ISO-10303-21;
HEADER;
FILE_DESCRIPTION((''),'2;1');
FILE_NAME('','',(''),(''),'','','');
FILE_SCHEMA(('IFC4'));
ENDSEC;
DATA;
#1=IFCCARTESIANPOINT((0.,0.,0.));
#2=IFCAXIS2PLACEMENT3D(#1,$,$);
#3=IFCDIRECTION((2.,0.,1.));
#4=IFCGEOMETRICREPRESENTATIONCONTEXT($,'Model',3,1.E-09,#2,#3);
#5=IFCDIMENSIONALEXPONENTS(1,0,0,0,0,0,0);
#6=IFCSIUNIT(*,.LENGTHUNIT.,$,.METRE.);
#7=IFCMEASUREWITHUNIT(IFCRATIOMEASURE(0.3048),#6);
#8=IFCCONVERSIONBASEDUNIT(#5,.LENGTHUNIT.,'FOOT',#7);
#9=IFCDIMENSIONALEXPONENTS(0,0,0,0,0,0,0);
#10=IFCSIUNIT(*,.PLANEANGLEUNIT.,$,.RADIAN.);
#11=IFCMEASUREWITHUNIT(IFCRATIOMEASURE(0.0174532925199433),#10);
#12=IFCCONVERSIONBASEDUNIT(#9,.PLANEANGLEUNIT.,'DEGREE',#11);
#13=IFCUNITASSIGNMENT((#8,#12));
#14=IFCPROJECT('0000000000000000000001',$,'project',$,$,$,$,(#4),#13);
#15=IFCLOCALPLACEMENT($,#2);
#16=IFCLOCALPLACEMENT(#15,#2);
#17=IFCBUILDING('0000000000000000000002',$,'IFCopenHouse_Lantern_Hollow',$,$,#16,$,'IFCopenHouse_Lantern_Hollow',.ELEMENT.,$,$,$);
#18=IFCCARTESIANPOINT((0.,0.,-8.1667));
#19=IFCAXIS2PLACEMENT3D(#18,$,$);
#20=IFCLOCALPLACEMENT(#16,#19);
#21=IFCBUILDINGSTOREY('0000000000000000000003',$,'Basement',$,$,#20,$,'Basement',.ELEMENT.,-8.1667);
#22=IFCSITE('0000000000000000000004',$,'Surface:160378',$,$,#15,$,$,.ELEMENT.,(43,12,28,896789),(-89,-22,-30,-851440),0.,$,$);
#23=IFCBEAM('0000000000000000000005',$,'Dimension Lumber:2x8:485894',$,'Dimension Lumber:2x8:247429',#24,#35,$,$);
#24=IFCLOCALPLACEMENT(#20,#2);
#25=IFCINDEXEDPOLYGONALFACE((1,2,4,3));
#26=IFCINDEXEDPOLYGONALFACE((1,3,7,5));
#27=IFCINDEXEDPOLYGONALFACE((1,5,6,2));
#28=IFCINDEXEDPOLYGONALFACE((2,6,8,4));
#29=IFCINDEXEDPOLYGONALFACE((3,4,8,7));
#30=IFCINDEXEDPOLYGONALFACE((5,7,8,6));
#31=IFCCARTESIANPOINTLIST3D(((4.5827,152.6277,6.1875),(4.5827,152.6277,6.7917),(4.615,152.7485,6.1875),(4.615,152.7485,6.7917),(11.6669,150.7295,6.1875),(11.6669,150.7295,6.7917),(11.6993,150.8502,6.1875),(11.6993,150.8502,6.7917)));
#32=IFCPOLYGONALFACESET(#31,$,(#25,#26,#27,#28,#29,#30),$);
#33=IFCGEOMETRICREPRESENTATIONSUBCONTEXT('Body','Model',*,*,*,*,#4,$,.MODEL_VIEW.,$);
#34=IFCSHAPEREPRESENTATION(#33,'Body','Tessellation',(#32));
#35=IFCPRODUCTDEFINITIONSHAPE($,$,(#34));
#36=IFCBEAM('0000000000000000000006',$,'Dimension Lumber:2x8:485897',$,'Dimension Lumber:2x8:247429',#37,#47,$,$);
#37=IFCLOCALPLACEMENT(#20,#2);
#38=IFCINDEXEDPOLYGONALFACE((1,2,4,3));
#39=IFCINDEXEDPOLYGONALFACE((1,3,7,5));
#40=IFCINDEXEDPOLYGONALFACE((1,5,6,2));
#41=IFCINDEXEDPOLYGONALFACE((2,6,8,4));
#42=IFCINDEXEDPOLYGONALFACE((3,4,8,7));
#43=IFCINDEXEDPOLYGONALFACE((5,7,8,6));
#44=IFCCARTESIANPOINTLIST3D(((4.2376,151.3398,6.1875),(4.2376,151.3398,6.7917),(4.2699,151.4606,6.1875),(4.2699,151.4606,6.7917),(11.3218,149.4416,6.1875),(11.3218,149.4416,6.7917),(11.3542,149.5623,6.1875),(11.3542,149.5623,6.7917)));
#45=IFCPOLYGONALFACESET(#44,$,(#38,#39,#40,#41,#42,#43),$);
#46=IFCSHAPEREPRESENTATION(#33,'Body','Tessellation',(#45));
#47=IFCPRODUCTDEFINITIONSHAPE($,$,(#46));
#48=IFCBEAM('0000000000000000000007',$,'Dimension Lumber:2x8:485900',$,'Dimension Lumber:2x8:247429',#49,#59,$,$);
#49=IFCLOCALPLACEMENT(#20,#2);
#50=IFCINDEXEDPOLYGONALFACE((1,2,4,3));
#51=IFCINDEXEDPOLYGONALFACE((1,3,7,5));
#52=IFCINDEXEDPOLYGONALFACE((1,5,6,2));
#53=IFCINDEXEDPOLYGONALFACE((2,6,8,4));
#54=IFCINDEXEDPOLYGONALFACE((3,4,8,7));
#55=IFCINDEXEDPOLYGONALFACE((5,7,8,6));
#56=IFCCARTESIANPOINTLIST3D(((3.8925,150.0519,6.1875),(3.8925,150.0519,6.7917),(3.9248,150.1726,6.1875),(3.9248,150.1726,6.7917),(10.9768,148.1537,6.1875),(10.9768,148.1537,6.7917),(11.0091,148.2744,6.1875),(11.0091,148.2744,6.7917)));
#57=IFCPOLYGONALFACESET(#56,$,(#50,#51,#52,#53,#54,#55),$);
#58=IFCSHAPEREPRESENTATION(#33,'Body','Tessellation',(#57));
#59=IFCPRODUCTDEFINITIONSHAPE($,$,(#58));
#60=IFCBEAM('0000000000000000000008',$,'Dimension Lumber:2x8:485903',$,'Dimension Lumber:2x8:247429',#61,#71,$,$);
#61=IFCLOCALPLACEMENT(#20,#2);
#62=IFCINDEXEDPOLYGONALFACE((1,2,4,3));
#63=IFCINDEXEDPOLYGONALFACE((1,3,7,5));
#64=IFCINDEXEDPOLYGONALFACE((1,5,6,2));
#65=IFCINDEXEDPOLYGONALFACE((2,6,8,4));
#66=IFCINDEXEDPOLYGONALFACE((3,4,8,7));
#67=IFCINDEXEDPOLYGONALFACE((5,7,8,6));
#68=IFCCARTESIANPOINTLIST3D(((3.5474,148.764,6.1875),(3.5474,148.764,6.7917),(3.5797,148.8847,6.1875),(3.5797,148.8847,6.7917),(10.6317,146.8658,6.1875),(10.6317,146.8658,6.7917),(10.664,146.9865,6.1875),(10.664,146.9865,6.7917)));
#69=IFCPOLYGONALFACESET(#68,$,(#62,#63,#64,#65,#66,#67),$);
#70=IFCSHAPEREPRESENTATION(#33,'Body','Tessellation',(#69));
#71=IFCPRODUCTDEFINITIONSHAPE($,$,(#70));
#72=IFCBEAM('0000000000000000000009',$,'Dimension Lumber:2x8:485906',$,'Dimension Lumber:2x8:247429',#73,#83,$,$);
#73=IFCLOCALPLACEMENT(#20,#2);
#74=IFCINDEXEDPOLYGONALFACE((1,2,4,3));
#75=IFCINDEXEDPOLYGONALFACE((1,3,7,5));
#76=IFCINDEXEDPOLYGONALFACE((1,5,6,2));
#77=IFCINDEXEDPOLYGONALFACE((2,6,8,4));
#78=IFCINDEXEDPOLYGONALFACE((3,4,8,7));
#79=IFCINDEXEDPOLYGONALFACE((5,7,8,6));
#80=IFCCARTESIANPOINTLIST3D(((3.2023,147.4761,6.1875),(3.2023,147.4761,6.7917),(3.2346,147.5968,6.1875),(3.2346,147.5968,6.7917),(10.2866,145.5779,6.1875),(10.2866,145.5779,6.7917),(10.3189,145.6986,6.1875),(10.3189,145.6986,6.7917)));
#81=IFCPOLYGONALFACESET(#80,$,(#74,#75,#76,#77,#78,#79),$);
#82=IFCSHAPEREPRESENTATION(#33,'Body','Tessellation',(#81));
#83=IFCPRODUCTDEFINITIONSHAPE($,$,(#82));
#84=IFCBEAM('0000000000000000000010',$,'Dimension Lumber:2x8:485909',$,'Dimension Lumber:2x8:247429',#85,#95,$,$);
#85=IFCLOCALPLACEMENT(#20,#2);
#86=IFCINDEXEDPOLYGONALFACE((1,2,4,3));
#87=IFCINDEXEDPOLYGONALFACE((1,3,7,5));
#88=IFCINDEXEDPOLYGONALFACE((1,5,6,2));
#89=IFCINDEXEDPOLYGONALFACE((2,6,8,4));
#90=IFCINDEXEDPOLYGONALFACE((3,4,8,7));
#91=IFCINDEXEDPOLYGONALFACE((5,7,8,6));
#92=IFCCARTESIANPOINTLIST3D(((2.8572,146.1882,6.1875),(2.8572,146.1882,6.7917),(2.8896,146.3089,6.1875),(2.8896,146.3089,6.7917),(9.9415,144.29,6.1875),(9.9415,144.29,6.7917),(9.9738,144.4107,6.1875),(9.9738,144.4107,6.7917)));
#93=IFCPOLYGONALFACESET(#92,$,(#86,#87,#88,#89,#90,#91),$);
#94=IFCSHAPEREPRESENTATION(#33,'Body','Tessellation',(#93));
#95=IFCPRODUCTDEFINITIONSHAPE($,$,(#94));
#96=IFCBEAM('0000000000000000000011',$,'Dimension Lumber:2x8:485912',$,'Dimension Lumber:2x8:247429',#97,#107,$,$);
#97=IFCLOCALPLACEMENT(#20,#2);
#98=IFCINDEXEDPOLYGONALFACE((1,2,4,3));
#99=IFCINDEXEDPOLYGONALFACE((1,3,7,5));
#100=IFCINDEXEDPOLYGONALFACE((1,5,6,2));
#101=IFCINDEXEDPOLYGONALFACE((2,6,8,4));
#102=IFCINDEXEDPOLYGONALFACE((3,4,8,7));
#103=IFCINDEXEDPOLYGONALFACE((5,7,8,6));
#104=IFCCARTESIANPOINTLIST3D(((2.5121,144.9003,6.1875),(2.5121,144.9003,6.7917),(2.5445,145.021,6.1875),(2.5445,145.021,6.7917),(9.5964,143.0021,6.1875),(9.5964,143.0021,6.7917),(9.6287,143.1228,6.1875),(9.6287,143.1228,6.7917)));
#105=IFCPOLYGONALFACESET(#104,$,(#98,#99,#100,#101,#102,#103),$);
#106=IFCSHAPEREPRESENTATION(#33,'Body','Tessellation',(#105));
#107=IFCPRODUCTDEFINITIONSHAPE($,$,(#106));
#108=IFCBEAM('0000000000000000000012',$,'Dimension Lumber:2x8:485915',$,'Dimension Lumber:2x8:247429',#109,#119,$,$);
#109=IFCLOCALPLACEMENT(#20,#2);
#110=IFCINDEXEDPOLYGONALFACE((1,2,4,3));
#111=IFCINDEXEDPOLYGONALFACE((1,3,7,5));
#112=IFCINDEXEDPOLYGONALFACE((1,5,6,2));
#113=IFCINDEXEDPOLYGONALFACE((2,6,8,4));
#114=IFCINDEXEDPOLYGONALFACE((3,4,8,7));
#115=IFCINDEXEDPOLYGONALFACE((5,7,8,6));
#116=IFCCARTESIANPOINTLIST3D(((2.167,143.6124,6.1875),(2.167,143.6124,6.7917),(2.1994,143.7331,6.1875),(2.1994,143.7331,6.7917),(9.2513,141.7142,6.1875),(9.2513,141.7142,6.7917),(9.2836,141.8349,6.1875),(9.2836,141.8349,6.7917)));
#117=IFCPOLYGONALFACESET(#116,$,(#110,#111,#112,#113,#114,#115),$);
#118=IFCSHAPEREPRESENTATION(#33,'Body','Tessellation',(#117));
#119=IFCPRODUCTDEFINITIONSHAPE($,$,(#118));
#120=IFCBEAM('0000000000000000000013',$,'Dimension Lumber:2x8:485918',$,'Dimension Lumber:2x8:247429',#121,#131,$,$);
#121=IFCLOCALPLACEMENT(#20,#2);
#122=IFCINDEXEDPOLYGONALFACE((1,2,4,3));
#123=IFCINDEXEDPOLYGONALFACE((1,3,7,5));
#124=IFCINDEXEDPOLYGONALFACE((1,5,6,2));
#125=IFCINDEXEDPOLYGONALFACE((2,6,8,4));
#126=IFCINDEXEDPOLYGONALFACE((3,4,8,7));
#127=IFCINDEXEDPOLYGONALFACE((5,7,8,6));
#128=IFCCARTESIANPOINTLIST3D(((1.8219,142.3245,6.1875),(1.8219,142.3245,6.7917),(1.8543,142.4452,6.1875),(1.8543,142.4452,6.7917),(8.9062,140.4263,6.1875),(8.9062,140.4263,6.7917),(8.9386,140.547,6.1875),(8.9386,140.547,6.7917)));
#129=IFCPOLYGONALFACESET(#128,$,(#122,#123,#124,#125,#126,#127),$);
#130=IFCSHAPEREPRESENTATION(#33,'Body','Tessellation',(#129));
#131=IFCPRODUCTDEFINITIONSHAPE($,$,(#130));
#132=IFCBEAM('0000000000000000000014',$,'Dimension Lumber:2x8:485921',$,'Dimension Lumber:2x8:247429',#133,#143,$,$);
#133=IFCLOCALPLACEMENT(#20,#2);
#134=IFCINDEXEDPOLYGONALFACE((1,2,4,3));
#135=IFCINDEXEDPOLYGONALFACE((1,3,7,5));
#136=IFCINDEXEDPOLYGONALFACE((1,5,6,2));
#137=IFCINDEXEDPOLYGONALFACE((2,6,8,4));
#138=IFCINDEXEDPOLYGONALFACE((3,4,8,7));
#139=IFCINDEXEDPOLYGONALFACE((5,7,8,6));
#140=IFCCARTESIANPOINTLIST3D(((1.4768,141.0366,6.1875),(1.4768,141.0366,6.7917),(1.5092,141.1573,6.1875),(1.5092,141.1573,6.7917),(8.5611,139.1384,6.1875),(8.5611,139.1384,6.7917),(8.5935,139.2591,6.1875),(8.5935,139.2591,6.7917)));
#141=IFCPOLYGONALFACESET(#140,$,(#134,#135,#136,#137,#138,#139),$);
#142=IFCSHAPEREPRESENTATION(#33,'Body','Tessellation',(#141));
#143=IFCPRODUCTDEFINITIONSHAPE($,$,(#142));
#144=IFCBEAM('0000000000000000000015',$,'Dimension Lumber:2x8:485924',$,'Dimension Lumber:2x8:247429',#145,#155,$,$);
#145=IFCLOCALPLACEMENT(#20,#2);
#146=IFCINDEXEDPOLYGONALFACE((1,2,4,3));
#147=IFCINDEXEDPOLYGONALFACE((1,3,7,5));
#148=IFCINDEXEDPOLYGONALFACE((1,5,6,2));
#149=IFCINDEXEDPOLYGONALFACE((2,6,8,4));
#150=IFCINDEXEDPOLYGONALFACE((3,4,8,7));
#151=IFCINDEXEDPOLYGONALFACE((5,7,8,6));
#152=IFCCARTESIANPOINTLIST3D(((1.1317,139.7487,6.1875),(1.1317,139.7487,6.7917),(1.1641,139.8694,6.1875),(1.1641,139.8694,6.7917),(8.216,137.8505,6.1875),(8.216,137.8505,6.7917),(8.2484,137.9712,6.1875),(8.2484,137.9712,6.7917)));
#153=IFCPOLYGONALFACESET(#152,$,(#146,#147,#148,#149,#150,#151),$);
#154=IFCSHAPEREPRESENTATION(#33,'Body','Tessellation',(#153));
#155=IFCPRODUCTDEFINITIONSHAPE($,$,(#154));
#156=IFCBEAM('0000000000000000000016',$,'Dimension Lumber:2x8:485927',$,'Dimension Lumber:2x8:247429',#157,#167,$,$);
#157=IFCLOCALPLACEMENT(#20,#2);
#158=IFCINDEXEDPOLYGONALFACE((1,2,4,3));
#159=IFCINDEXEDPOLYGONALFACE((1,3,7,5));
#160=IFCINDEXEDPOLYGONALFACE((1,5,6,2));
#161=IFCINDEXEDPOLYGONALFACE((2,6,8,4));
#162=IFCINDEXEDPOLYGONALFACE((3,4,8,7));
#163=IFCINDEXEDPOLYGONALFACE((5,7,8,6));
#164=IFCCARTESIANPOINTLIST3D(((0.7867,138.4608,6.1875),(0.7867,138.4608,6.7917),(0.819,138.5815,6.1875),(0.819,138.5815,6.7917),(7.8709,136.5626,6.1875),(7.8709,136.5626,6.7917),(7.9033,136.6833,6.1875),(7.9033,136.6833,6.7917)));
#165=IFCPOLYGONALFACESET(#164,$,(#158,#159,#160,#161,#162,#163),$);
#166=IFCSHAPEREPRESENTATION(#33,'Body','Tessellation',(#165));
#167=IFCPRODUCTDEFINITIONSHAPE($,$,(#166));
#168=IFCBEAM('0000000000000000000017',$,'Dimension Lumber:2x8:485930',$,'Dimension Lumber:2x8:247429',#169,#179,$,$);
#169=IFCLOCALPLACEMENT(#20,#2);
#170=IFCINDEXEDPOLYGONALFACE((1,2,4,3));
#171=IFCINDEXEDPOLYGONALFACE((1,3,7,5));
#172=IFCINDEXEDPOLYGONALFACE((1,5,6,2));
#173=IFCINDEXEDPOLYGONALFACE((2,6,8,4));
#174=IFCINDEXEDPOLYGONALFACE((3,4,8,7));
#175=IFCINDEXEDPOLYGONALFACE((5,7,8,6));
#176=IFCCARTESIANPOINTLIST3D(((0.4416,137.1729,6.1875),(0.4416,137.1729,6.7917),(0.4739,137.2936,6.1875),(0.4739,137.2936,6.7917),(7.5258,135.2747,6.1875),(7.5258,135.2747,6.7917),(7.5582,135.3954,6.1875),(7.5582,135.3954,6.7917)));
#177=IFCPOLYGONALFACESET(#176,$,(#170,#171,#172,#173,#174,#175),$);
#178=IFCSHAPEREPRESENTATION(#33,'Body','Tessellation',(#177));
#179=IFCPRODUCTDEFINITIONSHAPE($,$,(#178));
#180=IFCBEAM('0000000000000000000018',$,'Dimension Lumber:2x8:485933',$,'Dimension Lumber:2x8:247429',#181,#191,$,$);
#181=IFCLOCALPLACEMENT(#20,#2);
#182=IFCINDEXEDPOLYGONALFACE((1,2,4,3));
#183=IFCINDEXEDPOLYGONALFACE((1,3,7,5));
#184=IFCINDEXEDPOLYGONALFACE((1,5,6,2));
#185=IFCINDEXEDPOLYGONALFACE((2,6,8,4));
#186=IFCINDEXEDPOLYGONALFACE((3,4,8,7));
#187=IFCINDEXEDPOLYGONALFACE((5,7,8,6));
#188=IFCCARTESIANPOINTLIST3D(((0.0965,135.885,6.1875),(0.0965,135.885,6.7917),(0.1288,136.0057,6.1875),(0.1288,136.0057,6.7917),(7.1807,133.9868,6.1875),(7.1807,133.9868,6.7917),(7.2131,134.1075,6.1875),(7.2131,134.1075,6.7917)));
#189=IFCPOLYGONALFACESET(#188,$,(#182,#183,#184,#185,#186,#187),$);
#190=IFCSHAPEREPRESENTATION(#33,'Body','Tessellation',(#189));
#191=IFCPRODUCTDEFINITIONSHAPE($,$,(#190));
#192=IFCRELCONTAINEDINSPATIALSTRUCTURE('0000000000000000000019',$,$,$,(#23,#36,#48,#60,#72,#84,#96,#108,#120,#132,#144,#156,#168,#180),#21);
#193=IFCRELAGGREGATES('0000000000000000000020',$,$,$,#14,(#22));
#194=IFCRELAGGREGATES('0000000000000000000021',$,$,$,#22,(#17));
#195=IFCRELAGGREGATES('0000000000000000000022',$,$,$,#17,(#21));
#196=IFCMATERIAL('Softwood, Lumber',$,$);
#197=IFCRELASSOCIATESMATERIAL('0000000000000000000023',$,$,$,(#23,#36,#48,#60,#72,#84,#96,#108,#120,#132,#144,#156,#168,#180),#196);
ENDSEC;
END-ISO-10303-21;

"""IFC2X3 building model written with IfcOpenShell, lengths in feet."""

from ifc_helpers import new_model, entity, si_unit, converted_unit, direction, frame, frame_2d, origin, place, context, subcontext, project, spatial, rectangle, extrude, material, element, save


model = new_model("IFC2X3")

# Units and contexts
model_context = context("Model", 3, precision=1e-09, world=origin(), true_north=direction((2.0, 0.0, 1.0)))
body_context = subcontext(model_context, "Body", "Model", "MODEL_VIEW")
ifc_project = project(units=[converted_unit("LENGTHUNIT", "FOOT", entity("IfcRatioMeasure", 0.3048), si_unit("LENGTHUNIT", "METRE"), dimensions=[1, 0, 0, 0, 0, 0, 0]), converted_unit("PLANEANGLEUNIT", "DEGREE", entity("IfcRatioMeasure", 0.0174532925199433), si_unit("PLANEANGLEUNIT", "RADIAN"), dimensions=[0, 0, 0, 0, 0, 0, 0])], contexts=[model_context])

# Site, building, storey
site_placement = place(None, origin())
site = spatial("IfcSite", under=ifc_project, at=site_placement, Name="Surface:160378", CompositionType="ELEMENT", RefLatitude=(43, 12, 28, 896789), RefLongitude=(-89, -22, -30, -851440), RefElevation=0.0)
building_placement = place(site_placement, origin())
building = spatial("IfcBuilding", under=site, at=building_placement, Name="IFCopenHouse_Lantern_Hollow", LongName="IFCopenHouse_Lantern_Hollow", CompositionType="ELEMENT")
storey_placement = place(building_placement, frame((0.0, 0.0, -8.1667)))
storey = spatial("IfcBuildingStorey", under=building, at=storey_placement, Name="Basement", LongName="Basement", CompositionType="ELEMENT", Elevation=-8.1667)

# Beams
ifc_material_1 = material(Name="Softwood, Lumber")
beam_1_placement = place(storey_placement, frame((4.5988, 152.6881, 8.1667), z_axis=(0.0, 0.0, 1.0), x_axis=(0.965926, -0.258819, 0.0)))
element("IfcBeam", 1, at=beam_1_placement, inside=storey, material=ifc_material_1, Name="Dimension Lumber:2x8:485894", ObjectType="Dimension Lumber:2x8:247429", context=body_context, shape_type="SweptSolid", body=[
    extrude(rectangle(XDim=0.6042, YDim=0.125, at=frame_2d((0.0, 0.0), x_axis=(1.0, 0.0))), frame((0.0, 0.0, -1.6771), z_axis=(1.0, 0.0, 0.0), x_axis=(0.0, 0.0, -1.0)), (0.0, 0.0, 1.0), 7.3342),
])
beam_2_placement = place(storey_placement, frame((4.2537, 151.4002, 8.1667), z_axis=(0.0, 0.0, 1.0), x_axis=(0.965926, -0.258819, 0.0)))
element("IfcBeam", 2, at=beam_2_placement, inside=storey, material=ifc_material_1, Name="Dimension Lumber:2x8:485897", ObjectType="Dimension Lumber:2x8:247429", context=body_context, shape_type="SweptSolid", body=[
    extrude(rectangle(XDim=0.6042, YDim=0.125, at=frame_2d((0.0, 0.0), x_axis=(1.0, 0.0))), frame((0.0, 0.0, -1.6771), z_axis=(1.0, 0.0, 0.0), x_axis=(0.0, 0.0, -1.0)), (0.0, 0.0, 1.0), 7.3342),
])
beam_3_placement = place(storey_placement, frame((3.9087, 150.1123, 8.1667), z_axis=(0.0, 0.0, 1.0), x_axis=(0.965926, -0.258819, 0.0)))
element("IfcBeam", 3, at=beam_3_placement, inside=storey, material=ifc_material_1, Name="Dimension Lumber:2x8:485900", ObjectType="Dimension Lumber:2x8:247429", context=body_context, shape_type="SweptSolid", body=[
    extrude(rectangle(XDim=0.6042, YDim=0.125, at=frame_2d((0.0, 0.0), x_axis=(1.0, 0.0))), frame((0.0, 0.0, -1.6771), z_axis=(1.0, 0.0, 0.0), x_axis=(0.0, 0.0, -1.0)), (0.0, 0.0, 1.0), 7.3342),
])
beam_4_placement = place(storey_placement, frame((3.5636, 148.8244, 8.1667), z_axis=(0.0, 0.0, 1.0), x_axis=(0.965926, -0.258819, 0.0)))
element("IfcBeam", 4, at=beam_4_placement, inside=storey, material=ifc_material_1, Name="Dimension Lumber:2x8:485903", ObjectType="Dimension Lumber:2x8:247429", context=body_context, shape_type="SweptSolid", body=[
    extrude(rectangle(XDim=0.6042, YDim=0.125, at=frame_2d((0.0, 0.0), x_axis=(1.0, 0.0))), frame((0.0, 0.0, -1.6771), z_axis=(1.0, 0.0, 0.0), x_axis=(0.0, 0.0, -1.0)), (0.0, 0.0, 1.0), 7.3342),
])
for number, where, z_axis, x_axis, name in (
    (5, (3.2185, 147.5365, 8.1667), (0.0, 0.0, 1.0), (0.965926, -0.258819, 0.0), "Dimension Lumber:2x8:485906"),
    (6, (2.8734, 146.2486, 8.1667), (0.0, 0.0, 1.0), (0.965926, -0.258819, 0.0), "Dimension Lumber:2x8:485909"),
):
    element("IfcBeam", number, at=place(storey_placement, frame(where, z_axis=z_axis, x_axis=x_axis)), inside=storey, material=ifc_material_1, Name=name, ObjectType="Dimension Lumber:2x8:247429", context=body_context, shape_type="SweptSolid", body=[
        extrude(rectangle(XDim=0.6042, YDim=0.125, at=frame_2d((0.0, 0.0), x_axis=(1.0, 0.0))), frame((0.0, 0.0, -1.6771), z_axis=(1.0, 0.0, 0.0), x_axis=(0.0, 0.0, -1.0)), (0.0, 0.0, 1.0), 7.3342),
    ])
beam_5_placement = place(storey_placement, frame((2.5283, 144.9607, 8.1667), z_axis=(0.0, 0.0, 1.0), x_axis=(0.965926, -0.258819, 0.0)))
element("IfcBeam", 7, at=beam_5_placement, inside=storey, material=ifc_material_1, Name="Dimension Lumber:2x8:485912", ObjectType="Dimension Lumber:2x8:247429", context=body_context, shape_type="SweptSolid", body=[
    extrude(rectangle(XDim=0.6042, YDim=0.125, at=frame_2d((0.0, 0.0), x_axis=(1.0, 0.0))), frame((0.0, 0.0, -1.6771), z_axis=(1.0, 0.0, 0.0), x_axis=(0.0, 0.0, -1.0)), (0.0, 0.0, 1.0), 7.3342),
])
beam_6_placement = place(storey_placement, frame((2.1832, 143.6728, 8.1667), z_axis=(0.0, 0.0, 1.0), x_axis=(0.965926, -0.258819, 0.0)))
element("IfcBeam", 8, at=beam_6_placement, inside=storey, material=ifc_material_1, Name="Dimension Lumber:2x8:485915", ObjectType="Dimension Lumber:2x8:247429", context=body_context, shape_type="SweptSolid", body=[
    extrude(rectangle(XDim=0.6042, YDim=0.125, at=frame_2d((0.0, 0.0), x_axis=(1.0, 0.0))), frame((0.0, 0.0, -1.6771), z_axis=(1.0, 0.0, 0.0), x_axis=(0.0, 0.0, -1.0)), (0.0, 0.0, 1.0), 7.3342),
])
beam_7_placement = place(storey_placement, frame((1.8381, 142.3849, 8.1667), z_axis=(0.0, 0.0, 1.0), x_axis=(0.965926, -0.258819, 0.0)))
element("IfcBeam", 9, at=beam_7_placement, inside=storey, material=ifc_material_1, Name="Dimension Lumber:2x8:485918", ObjectType="Dimension Lumber:2x8:247429", context=body_context, shape_type="SweptSolid", body=[
    extrude(rectangle(XDim=0.6042, YDim=0.125, at=frame_2d((0.0, 0.0), x_axis=(1.0, 0.0))), frame((0.0, 0.0, -1.6771), z_axis=(1.0, 0.0, 0.0), x_axis=(0.0, 0.0, -1.0)), (0.0, 0.0, 1.0), 7.3342),
])
beam_8_placement = place(storey_placement, frame((1.493, 141.097, 8.1667), z_axis=(0.0, 0.0, 1.0), x_axis=(0.965926, -0.258819, 0.0)))
element("IfcBeam", 10, at=beam_8_placement, inside=storey, material=ifc_material_1, Name="Dimension Lumber:2x8:485921", ObjectType="Dimension Lumber:2x8:247429", context=body_context, shape_type="SweptSolid", body=[
    extrude(rectangle(XDim=0.6042, YDim=0.125, at=frame_2d((0.0, 0.0), x_axis=(1.0, 0.0))), frame((0.0, 0.0, -1.6771), z_axis=(1.0, 0.0, 0.0), x_axis=(0.0, 0.0, -1.0)), (0.0, 0.0, 1.0), 7.3342),
])
beam_9_placement = place(storey_placement, frame((1.1479, 139.8091, 8.1667), z_axis=(0.0, 0.0, 1.0), x_axis=(0.965926, -0.258819, 0.0)))
element("IfcBeam", 11, at=beam_9_placement, inside=storey, material=ifc_material_1, Name="Dimension Lumber:2x8:485924", ObjectType="Dimension Lumber:2x8:247429", context=body_context, shape_type="SweptSolid", body=[
    extrude(rectangle(XDim=0.6042, YDim=0.125, at=frame_2d((0.0, 0.0), x_axis=(1.0, 0.0))), frame((0.0, 0.0, -1.6771), z_axis=(1.0, 0.0, 0.0), x_axis=(0.0, 0.0, -1.0)), (0.0, 0.0, 1.0), 7.3342),
])
beam_10_placement = place(storey_placement, frame((0.8028, 138.5212, 8.1667), z_axis=(0.0, 0.0, 1.0), x_axis=(0.965926, -0.258819, 0.0)))
element("IfcBeam", 12, at=beam_10_placement, inside=storey, material=ifc_material_1, Name="Dimension Lumber:2x8:485927", ObjectType="Dimension Lumber:2x8:247429", context=body_context, shape_type="SweptSolid", body=[
    extrude(rectangle(XDim=0.6042, YDim=0.125, at=frame_2d((0.0, 0.0), x_axis=(1.0, 0.0))), frame((0.0, 0.0, -1.6771), z_axis=(1.0, 0.0, 0.0), x_axis=(0.0, 0.0, -1.0)), (0.0, 0.0, 1.0), 7.3342),
])
beam_11_placement = place(storey_placement, frame((0.4577, 137.2333, 8.1667), z_axis=(0.0, 0.0, 1.0), x_axis=(0.965926, -0.258819, 0.0)))
element("IfcBeam", 13, at=beam_11_placement, inside=storey, material=ifc_material_1, Name="Dimension Lumber:2x8:485930", ObjectType="Dimension Lumber:2x8:247429", context=body_context, shape_type="SweptSolid", body=[
    extrude(rectangle(XDim=0.6042, YDim=0.125, at=frame_2d((0.0, 0.0), x_axis=(1.0, 0.0))), frame((0.0, 0.0, -1.6771), z_axis=(1.0, 0.0, 0.0), x_axis=(0.0, 0.0, -1.0)), (0.0, 0.0, 1.0), 7.3342),
])
beam_12_placement = place(storey_placement, frame((0.1126, 135.9454, 8.1667), z_axis=(0.0, 0.0, 1.0), x_axis=(0.965926, -0.258819, 0.0)))
element("IfcBeam", 14, at=beam_12_placement, inside=storey, material=ifc_material_1, Name="Dimension Lumber:2x8:485933", ObjectType="Dimension Lumber:2x8:247429", context=body_context, shape_type="SweptSolid", body=[
    extrude(rectangle(XDim=0.6042, YDim=0.125, at=frame_2d((0.0, 0.0), x_axis=(1.0, 0.0))), frame((0.0, 0.0, -1.6771), z_axis=(1.0, 0.0, 0.0), x_axis=(0.0, 0.0, -1.0)), (0.0, 0.0, 1.0), 7.3342),
])

save(model, "model.ifc")
